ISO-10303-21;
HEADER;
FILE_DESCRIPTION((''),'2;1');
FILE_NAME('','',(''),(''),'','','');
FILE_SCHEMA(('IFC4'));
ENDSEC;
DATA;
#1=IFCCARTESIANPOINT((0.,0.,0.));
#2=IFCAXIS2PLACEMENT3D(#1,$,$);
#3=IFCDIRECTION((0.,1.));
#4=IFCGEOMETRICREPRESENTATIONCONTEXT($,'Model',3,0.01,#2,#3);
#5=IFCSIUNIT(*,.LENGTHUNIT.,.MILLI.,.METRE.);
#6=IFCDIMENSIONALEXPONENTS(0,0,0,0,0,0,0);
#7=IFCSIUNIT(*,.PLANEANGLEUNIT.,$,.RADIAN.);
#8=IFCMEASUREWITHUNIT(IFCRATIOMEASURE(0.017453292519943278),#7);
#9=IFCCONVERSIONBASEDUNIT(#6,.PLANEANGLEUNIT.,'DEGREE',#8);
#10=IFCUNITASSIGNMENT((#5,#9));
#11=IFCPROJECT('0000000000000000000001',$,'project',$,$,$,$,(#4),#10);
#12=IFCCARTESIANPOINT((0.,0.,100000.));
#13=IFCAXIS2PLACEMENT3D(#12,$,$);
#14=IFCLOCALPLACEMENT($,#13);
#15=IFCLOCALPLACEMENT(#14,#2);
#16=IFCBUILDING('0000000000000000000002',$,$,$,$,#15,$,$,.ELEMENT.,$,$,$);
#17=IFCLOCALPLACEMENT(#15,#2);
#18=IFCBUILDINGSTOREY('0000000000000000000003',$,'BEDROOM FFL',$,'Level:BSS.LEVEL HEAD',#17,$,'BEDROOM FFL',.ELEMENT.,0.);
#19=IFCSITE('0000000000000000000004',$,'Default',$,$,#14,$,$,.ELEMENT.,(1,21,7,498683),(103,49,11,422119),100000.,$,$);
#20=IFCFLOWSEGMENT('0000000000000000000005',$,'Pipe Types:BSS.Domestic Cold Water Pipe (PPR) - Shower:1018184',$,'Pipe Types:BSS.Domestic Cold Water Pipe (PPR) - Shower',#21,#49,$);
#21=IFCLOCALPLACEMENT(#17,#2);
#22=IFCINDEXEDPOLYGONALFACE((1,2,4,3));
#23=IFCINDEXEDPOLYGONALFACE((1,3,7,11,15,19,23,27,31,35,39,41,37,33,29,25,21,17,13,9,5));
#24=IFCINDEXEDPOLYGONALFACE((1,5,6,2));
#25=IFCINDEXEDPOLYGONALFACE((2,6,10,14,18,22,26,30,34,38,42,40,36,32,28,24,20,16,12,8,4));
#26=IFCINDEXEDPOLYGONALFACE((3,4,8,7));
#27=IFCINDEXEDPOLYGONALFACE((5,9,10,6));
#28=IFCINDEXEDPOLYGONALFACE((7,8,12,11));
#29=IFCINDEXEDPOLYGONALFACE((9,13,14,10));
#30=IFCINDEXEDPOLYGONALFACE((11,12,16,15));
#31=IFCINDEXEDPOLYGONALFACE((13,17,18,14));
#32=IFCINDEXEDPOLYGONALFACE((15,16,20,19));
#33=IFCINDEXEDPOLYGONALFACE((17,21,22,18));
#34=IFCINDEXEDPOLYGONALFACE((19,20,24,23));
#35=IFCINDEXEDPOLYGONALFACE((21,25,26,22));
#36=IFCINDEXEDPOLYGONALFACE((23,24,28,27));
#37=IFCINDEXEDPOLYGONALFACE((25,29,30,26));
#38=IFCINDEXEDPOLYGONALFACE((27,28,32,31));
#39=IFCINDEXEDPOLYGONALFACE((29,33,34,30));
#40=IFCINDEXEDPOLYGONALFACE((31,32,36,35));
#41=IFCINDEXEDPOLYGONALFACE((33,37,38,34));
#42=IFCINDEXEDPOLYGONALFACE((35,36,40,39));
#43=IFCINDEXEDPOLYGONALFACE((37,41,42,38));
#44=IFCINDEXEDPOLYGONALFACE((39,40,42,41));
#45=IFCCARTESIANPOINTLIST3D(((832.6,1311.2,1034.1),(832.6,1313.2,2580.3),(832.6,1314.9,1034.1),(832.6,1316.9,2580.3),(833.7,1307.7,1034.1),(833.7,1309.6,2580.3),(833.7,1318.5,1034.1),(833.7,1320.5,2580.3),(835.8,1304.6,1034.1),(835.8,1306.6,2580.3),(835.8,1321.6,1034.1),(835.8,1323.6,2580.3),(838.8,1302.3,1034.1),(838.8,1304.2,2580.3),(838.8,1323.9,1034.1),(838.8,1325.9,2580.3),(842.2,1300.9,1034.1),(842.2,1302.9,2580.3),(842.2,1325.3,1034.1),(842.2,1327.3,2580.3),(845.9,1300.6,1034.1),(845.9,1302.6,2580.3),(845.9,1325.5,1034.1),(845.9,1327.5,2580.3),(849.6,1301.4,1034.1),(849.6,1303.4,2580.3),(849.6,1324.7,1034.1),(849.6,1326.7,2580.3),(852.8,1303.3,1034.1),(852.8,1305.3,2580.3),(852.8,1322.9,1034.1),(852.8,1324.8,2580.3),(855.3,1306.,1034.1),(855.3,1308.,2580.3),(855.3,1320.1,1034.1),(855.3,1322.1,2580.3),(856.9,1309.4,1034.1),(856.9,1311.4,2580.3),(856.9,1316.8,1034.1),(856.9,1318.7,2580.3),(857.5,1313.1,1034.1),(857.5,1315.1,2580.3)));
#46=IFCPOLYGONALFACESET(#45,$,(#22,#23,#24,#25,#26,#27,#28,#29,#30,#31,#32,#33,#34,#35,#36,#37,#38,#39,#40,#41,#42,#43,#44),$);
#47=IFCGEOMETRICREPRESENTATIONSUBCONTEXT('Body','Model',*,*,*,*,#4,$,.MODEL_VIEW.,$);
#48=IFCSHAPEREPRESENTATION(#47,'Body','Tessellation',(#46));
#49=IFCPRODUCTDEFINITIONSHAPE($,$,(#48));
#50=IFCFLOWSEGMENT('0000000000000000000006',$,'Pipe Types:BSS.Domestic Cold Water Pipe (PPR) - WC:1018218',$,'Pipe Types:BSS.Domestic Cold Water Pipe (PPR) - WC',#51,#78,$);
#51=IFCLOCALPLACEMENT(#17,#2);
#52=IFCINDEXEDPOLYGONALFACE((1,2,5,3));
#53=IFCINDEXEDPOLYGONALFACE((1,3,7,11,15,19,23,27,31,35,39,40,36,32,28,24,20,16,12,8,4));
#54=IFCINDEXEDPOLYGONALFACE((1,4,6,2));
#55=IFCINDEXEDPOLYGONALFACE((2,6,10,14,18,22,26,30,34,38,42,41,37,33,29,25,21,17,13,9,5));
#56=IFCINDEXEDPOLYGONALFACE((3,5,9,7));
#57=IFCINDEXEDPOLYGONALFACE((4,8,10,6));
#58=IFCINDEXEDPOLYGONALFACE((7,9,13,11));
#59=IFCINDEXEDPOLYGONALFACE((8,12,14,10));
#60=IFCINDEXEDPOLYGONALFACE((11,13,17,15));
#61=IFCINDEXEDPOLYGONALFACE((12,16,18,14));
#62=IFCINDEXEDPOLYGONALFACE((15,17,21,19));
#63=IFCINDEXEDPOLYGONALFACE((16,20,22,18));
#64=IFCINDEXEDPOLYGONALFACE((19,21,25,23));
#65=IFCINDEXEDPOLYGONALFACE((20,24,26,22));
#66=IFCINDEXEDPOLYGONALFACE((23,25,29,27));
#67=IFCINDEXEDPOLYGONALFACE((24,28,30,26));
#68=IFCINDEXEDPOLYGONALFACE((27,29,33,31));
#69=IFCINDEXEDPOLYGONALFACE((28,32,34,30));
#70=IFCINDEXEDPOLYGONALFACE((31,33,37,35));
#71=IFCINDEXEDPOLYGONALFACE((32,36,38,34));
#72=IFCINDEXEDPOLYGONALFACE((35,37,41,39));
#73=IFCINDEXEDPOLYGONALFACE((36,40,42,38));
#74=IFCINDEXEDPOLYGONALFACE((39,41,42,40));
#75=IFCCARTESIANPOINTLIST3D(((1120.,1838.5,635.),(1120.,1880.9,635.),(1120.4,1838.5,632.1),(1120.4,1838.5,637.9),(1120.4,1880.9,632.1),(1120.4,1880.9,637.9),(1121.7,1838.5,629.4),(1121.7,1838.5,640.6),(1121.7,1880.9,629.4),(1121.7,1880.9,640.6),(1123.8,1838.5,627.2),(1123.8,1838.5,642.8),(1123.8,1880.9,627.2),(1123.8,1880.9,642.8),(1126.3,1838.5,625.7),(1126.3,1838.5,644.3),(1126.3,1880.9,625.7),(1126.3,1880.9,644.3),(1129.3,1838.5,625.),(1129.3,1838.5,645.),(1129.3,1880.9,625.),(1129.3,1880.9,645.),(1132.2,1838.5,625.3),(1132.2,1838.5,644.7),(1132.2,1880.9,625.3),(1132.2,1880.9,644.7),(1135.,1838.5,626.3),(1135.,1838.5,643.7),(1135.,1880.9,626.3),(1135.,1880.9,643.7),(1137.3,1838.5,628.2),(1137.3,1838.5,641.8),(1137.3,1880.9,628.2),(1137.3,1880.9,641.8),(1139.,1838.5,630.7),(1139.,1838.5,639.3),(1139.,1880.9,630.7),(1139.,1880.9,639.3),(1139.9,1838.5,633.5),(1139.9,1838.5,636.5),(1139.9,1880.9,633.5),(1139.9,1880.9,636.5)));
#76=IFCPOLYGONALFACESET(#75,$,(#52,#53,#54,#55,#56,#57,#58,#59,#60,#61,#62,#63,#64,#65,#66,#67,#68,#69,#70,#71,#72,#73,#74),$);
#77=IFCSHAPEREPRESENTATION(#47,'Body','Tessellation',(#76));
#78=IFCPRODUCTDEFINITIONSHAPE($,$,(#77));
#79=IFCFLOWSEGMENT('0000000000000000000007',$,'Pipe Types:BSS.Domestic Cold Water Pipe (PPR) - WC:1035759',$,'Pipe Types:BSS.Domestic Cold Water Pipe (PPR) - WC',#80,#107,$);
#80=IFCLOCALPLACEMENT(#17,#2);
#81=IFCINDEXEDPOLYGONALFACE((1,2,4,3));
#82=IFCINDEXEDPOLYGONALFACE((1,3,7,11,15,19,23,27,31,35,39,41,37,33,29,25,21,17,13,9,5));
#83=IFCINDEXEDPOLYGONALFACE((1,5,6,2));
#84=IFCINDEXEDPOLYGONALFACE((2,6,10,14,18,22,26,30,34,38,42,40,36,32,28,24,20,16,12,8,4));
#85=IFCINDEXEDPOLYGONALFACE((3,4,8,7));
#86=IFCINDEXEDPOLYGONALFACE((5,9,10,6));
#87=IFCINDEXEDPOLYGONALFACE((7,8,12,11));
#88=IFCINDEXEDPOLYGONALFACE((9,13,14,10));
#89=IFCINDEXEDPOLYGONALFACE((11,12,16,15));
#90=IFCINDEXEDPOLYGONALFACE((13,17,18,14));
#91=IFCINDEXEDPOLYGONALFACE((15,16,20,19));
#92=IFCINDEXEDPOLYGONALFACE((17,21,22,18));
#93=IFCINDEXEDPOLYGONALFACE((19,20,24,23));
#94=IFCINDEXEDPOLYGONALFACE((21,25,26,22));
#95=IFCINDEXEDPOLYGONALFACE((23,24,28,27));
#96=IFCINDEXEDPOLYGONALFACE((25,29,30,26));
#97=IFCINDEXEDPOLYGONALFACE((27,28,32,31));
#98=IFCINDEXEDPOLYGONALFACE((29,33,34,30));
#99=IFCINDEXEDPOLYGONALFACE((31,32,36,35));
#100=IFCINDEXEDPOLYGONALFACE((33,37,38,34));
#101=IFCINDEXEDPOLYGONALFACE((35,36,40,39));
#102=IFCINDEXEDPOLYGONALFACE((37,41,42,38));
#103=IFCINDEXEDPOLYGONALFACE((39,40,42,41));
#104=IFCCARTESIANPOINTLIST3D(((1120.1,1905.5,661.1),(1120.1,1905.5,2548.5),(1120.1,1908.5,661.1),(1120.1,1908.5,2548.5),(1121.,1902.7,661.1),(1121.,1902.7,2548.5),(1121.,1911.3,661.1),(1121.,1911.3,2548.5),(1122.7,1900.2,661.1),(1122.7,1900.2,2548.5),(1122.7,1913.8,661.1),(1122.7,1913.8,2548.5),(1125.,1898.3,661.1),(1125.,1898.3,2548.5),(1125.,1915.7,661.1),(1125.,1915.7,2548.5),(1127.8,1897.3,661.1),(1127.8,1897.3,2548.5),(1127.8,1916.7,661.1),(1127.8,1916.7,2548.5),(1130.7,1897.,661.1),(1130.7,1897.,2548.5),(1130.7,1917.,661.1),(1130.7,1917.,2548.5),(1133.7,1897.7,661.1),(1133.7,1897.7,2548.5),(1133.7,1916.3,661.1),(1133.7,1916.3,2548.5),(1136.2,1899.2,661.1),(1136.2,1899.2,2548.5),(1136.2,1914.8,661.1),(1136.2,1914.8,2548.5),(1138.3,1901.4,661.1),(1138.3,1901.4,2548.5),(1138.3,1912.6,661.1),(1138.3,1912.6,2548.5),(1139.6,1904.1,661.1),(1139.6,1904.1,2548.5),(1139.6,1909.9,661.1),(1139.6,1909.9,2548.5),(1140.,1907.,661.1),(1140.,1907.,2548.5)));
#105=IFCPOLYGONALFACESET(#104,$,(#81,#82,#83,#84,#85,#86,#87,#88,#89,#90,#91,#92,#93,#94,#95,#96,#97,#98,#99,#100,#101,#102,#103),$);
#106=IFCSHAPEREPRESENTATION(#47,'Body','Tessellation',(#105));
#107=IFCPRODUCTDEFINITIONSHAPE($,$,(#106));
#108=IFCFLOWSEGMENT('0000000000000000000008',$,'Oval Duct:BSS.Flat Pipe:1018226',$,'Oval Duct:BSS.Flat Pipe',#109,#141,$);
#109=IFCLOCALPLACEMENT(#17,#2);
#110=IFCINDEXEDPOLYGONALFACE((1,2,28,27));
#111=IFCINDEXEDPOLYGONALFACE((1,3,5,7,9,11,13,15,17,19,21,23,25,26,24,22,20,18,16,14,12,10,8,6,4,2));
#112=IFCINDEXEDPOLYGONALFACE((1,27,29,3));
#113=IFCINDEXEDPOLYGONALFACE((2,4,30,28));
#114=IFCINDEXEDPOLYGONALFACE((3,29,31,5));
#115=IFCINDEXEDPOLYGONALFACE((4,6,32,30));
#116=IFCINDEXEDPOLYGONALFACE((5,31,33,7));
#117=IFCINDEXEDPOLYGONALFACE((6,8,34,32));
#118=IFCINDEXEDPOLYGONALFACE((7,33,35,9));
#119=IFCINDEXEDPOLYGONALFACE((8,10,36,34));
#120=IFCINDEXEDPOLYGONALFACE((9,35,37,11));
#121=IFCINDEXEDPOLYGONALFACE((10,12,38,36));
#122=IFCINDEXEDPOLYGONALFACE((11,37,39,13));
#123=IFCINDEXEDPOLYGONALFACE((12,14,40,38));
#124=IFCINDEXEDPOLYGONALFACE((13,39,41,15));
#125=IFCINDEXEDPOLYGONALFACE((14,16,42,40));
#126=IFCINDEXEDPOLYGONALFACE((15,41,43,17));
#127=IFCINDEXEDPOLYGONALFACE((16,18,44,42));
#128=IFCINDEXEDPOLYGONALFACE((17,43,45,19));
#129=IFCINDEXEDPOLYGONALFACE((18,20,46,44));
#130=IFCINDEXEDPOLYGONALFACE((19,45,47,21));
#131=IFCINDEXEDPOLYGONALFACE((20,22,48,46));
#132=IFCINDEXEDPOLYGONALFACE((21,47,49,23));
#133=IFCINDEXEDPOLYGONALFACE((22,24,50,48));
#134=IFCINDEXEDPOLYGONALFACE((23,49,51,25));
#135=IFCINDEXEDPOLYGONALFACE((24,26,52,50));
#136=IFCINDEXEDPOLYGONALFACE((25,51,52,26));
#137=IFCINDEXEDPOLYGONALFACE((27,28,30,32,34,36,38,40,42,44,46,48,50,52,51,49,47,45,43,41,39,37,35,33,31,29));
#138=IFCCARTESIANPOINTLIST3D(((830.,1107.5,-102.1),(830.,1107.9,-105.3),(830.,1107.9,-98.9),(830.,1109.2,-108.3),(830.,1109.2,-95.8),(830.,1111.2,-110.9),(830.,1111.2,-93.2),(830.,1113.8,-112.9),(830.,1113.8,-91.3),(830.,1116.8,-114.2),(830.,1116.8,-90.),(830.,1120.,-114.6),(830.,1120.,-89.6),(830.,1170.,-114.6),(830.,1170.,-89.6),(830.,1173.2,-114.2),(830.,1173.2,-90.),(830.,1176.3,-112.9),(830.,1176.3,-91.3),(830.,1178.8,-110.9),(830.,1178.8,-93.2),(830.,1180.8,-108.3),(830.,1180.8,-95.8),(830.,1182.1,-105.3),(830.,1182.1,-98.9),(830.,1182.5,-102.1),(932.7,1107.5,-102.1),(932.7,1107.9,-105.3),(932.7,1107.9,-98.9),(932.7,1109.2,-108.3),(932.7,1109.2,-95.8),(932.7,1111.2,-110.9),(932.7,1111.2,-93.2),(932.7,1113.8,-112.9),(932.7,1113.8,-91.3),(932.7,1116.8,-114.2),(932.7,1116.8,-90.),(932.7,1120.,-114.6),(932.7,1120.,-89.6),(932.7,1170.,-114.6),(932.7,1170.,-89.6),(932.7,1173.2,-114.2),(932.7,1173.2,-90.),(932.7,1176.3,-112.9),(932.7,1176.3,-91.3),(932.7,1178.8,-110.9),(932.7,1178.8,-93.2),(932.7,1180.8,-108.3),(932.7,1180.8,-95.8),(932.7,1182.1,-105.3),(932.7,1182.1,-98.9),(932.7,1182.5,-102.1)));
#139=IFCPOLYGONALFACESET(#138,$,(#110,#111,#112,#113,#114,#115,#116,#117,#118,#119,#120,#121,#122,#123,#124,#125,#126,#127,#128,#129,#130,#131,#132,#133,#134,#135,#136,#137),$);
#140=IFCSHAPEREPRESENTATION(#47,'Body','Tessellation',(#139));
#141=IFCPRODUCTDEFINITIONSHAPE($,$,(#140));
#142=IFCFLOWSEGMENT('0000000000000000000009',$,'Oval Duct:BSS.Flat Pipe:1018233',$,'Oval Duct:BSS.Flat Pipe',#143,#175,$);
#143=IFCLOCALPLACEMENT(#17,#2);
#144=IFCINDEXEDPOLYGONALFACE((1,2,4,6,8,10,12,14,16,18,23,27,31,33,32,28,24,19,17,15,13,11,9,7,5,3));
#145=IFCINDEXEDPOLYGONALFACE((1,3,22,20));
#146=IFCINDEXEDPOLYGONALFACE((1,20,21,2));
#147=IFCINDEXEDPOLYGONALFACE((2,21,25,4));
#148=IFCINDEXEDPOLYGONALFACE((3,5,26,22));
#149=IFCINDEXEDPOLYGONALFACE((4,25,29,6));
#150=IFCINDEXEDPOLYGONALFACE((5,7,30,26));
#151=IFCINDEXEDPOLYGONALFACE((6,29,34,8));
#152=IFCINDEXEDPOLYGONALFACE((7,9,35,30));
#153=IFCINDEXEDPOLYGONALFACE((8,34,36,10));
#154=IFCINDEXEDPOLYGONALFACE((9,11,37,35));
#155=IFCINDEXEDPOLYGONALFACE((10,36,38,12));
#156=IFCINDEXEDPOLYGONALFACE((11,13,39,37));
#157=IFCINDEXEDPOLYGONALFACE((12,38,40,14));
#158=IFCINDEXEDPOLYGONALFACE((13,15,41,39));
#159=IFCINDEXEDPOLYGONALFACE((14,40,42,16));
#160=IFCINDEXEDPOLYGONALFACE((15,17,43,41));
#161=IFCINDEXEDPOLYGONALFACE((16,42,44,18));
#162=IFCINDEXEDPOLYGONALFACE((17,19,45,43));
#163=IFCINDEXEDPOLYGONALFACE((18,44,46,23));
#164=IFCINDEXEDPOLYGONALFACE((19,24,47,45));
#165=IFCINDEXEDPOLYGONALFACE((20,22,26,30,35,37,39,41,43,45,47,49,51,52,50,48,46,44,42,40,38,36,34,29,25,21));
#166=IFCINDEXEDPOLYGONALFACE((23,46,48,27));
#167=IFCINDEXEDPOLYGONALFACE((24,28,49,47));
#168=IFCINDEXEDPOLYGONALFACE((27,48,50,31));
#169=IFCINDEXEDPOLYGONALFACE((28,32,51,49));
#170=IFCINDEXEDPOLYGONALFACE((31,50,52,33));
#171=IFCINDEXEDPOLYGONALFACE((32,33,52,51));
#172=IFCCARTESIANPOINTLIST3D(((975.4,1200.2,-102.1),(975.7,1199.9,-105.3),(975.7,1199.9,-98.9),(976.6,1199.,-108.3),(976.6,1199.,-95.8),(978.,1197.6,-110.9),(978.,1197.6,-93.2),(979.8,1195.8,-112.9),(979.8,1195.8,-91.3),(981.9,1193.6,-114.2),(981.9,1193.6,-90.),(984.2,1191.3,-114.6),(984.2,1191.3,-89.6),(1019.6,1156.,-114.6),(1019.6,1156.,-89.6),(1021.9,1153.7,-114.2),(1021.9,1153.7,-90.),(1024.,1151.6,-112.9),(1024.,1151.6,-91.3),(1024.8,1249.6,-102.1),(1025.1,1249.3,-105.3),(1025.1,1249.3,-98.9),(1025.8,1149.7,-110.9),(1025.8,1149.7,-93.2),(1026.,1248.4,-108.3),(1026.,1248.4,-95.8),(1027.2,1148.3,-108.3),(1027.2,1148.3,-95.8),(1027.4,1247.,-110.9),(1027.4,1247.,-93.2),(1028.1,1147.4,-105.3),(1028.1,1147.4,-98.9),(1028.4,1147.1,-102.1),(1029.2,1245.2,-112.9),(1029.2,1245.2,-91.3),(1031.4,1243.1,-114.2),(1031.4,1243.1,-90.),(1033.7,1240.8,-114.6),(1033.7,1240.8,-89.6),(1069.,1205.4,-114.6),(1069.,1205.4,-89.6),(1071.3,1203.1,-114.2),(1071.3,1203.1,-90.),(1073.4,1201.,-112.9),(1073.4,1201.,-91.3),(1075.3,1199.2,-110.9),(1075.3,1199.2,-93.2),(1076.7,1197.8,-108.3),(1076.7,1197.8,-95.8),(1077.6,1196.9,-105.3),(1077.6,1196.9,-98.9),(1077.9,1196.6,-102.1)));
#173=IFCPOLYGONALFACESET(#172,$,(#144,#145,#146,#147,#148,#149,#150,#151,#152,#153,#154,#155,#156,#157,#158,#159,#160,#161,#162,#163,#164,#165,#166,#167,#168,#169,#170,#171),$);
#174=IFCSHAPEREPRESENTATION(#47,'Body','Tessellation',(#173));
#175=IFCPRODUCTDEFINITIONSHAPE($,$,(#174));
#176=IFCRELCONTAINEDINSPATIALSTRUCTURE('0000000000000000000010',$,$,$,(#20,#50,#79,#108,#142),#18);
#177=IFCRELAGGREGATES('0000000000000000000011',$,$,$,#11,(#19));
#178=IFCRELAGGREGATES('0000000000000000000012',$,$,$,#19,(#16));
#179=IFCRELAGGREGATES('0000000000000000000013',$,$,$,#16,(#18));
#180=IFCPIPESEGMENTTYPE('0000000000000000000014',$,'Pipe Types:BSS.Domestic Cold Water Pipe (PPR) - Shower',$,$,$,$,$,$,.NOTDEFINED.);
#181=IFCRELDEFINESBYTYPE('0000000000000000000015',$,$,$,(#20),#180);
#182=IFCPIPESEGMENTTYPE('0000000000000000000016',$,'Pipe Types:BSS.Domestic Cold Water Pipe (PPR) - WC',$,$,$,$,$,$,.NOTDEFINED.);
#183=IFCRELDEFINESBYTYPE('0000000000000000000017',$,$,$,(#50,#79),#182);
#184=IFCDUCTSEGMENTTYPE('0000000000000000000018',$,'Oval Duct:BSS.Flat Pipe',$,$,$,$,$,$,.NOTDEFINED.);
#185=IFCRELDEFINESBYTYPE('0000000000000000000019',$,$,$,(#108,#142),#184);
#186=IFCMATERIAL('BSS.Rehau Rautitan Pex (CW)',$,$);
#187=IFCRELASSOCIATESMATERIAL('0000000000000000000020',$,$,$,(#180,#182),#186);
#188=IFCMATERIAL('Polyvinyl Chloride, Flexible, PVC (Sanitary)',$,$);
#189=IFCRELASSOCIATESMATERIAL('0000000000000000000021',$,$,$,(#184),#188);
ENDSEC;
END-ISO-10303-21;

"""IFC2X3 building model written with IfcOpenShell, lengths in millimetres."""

from ifc_helpers import new_model, entity, si_unit, converted_unit, direction, frame, frame_2d, origin, origin_2d_with_axis, place, context, subcontext, project, spatial, polyline, circle_curve, parameter, trimmed, segment, composite_curve, circle, outline, extrude, material, type_object, element, save


model = new_model("IFC2X3")

# Units and contexts
model_context = context("Model", 3, precision=0.01, world=origin(), true_north=direction((0.0, 1.0)))
body_context = subcontext(model_context, "Body", "Model", "MODEL_VIEW")
ifc_project = project(units=[si_unit("LENGTHUNIT", "METRE", prefix="MILLI"), converted_unit("PLANEANGLEUNIT", "DEGREE", entity("IfcRatioMeasure", 0.017453292519943278), si_unit("PLANEANGLEUNIT", "RADIAN"), dimensions=[0, 0, 0, 0, 0, 0, 0])], contexts=[model_context])

# Site, building, storey
site_placement = place(None, frame((0.0, 0.0, 100000.0)))
site = spatial("IfcSite", under=ifc_project, at=site_placement, Name="Default", CompositionType="ELEMENT", RefLatitude=(1, 21, 7, 498683), RefLongitude=(103, 49, 11, 422119), RefElevation=100000.0)
building_placement = place(site_placement, origin())
building = spatial("IfcBuilding", under=site, at=building_placement, CompositionType="ELEMENT")
storey_placement = place(building_placement, origin())
storey = spatial("IfcBuildingStorey", under=building, at=storey_placement, Name="BEDROOM FFL", ObjectType="Level:BSS.LEVEL HEAD", LongName="BEDROOM FFL", CompositionType="ELEMENT", Elevation=0.0)

# Flow segments
ifc_material_1 = material(Name="Polyvinyl Chloride, Flexible, PVC (Sanitary)")
ifc_material_2 = material(Name="BSS.Rehau Rautitan Pex (CW)")
pipe_segment_type_1 = type_object("IfcPipeSegmentType", Name="Pipe Types:BSS.Domestic Cold Water Pipe (PPR) - Shower", PredefinedType="NOTDEFINED", material=ifc_material_2)
flow_segment_1_placement = place(storey_placement, origin())
element("IfcFlowSegment", 1, at=flow_segment_1_placement, inside=storey, type_object=pipe_segment_type_1, Name="Pipe Types:BSS.Domestic Cold Water Pipe (PPR) - Shower:1018184", ObjectType="Pipe Types:BSS.Domestic Cold Water Pipe (PPR) - Shower", context=body_context, shape_type="SweptSolid", body=[
    extrude(circle(Radius=12.5, at=frame_2d((0.0, 0.0), x_axis=(1.0, 0.0))), frame((845.0, 1313.1, 1034.1), z_axis=(0.000001, 0.001284, 0.999999), x_axis=(1.0, 0.0, -0.000001)), (0.0, 0.0, 1.0), 1546.2),
])
pipe_segment_type_2 = type_object("IfcPipeSegmentType", Name="Pipe Types:BSS.Domestic Cold Water Pipe (PPR) - WC", PredefinedType="NOTDEFINED", material=ifc_material_2)
flow_segment_2_placement = place(storey_placement, origin())
element("IfcFlowSegment", 2, at=flow_segment_2_placement, inside=storey, type_object=pipe_segment_type_2, Name="Pipe Types:BSS.Domestic Cold Water Pipe (PPR) - WC:1018218", ObjectType="Pipe Types:BSS.Domestic Cold Water Pipe (PPR) - WC", context=body_context, shape_type="SweptSolid", body=[
    extrude(circle(Radius=10.0, at=origin_2d_with_axis()), frame((1130.0, 1838.5, 635.0), z_axis=(0.0, 1.0, 0.0), x_axis=(-1.0, 0.0, 0.0)), (0.0, 0.0, 1.0), 42.4),
])
flow_segment_3_placement = place(storey_placement, origin())
element("IfcFlowSegment", 3, at=flow_segment_3_placement, inside=storey, type_object=pipe_segment_type_2, Name="Pipe Types:BSS.Domestic Cold Water Pipe (PPR) - WC:1035759", ObjectType="Pipe Types:BSS.Domestic Cold Water Pipe (PPR) - WC", context=body_context, shape_type="SweptSolid", body=[
    extrude(circle(Radius=10.0, at=frame_2d((0.0, 0.0), x_axis=(1.0, 0.0))), frame((1130.0, 1907.0, 661.1)), (0.0, 0.0, 1.0), 1887.4),
])
duct_segment_type = type_object("IfcDuctSegmentType", Name="Oval Duct:BSS.Flat Pipe", PredefinedType="NOTDEFINED", material=ifc_material_1)
flow_segment_4_placement = place(storey_placement, origin())
element("IfcFlowSegment", 4, at=flow_segment_4_placement, inside=storey, type_object=duct_segment_type, Name="Oval Duct:BSS.Flat Pipe:1018226", ObjectType="Oval Duct:BSS.Flat Pipe", context=body_context, shape_type="SweptSolid", body=[
    extrude(outline(composite_curve([segment(polyline([(-25.0, -12.5), (25.0, -12.5)]), True, "CONTINUOUS"), segment(trimmed(circle_curve(frame_2d((25.0, 0.0), x_axis=(-1.0, 0.0)), 12.5), [parameter(90.0)], [parameter(180.0)], True, "PARAMETER"), True, "CONTINUOUS"), segment(trimmed(circle_curve(frame_2d((25.0, 0.0), x_axis=(-1.0, 0.0)), 12.5), [parameter(180.0)], [parameter(270.0)], True, "PARAMETER"), True, "CONTINUOUS"), segment(polyline([(25.0, 12.5), (-25.0, 12.5)]), True, "CONTINUOUS"), segment(trimmed(circle_curve(frame_2d((-25.0, 0.0), x_axis=(-1.0, 0.0)), 12.5), [parameter(270.0)], [parameter(0.0)], True, "PARAMETER"), True, "CONTINUOUS"), segment(trimmed(circle_curve(frame_2d((-25.0, 0.0), x_axis=(-1.0, 0.0)), 12.5), [parameter(0.0)], [parameter(90.0)], True, "PARAMETER"), True, "CONTINUOUS")], self_intersect=False)), frame((830.0, 1145.0, -102.1), z_axis=(1.0, 0.0, 0.0), x_axis=(0.0, -1.0, 0.0)), (0.0, 0.0, 1.0), 102.7),
])
flow_segment_5_placement = place(storey_placement, origin())
element("IfcFlowSegment", 5, at=flow_segment_5_placement, inside=storey, type_object=duct_segment_type, Name="Oval Duct:BSS.Flat Pipe:1018233", ObjectType="Oval Duct:BSS.Flat Pipe", context=body_context, shape_type="SweptSolid", body=[
    extrude(outline(composite_curve([segment(polyline([(-25.0, -12.5), (25.0, -12.5)]), True, "CONTINUOUS"), segment(trimmed(circle_curve(frame_2d((25.0, 0.0), x_axis=(-1.0, 0.0)), 12.5), [parameter(90.0)], [parameter(180.0)], True, "PARAMETER"), True, "CONTINUOUS"), segment(trimmed(circle_curve(frame_2d((25.0, 0.0), x_axis=(-1.0, 0.0)), 12.5), [parameter(180.0)], [parameter(270.0)], True, "PARAMETER"), True, "CONTINUOUS"), segment(polyline([(25.0, 12.5), (-25.0, 12.5)]), True, "CONTINUOUS"), segment(trimmed(circle_curve(frame_2d((-25.0, 0.0), x_axis=(-1.0, 0.0)), 12.5), [parameter(270.0)], [parameter(0.0)], True, "PARAMETER"), True, "CONTINUOUS"), segment(trimmed(circle_curve(frame_2d((-25.0, 0.0), x_axis=(-1.0, 0.0)), 12.5), [parameter(0.0)], [parameter(90.0)], True, "PARAMETER"), True, "CONTINUOUS")], self_intersect=False)), frame((1001.9, 1173.7, -102.1), z_axis=(0.707108, 0.707105, 0.0), x_axis=(0.707105, -0.707108, 0.0)), (0.0, 0.0, 1.0), 69.9),
])

save(model, "model.ifc")
